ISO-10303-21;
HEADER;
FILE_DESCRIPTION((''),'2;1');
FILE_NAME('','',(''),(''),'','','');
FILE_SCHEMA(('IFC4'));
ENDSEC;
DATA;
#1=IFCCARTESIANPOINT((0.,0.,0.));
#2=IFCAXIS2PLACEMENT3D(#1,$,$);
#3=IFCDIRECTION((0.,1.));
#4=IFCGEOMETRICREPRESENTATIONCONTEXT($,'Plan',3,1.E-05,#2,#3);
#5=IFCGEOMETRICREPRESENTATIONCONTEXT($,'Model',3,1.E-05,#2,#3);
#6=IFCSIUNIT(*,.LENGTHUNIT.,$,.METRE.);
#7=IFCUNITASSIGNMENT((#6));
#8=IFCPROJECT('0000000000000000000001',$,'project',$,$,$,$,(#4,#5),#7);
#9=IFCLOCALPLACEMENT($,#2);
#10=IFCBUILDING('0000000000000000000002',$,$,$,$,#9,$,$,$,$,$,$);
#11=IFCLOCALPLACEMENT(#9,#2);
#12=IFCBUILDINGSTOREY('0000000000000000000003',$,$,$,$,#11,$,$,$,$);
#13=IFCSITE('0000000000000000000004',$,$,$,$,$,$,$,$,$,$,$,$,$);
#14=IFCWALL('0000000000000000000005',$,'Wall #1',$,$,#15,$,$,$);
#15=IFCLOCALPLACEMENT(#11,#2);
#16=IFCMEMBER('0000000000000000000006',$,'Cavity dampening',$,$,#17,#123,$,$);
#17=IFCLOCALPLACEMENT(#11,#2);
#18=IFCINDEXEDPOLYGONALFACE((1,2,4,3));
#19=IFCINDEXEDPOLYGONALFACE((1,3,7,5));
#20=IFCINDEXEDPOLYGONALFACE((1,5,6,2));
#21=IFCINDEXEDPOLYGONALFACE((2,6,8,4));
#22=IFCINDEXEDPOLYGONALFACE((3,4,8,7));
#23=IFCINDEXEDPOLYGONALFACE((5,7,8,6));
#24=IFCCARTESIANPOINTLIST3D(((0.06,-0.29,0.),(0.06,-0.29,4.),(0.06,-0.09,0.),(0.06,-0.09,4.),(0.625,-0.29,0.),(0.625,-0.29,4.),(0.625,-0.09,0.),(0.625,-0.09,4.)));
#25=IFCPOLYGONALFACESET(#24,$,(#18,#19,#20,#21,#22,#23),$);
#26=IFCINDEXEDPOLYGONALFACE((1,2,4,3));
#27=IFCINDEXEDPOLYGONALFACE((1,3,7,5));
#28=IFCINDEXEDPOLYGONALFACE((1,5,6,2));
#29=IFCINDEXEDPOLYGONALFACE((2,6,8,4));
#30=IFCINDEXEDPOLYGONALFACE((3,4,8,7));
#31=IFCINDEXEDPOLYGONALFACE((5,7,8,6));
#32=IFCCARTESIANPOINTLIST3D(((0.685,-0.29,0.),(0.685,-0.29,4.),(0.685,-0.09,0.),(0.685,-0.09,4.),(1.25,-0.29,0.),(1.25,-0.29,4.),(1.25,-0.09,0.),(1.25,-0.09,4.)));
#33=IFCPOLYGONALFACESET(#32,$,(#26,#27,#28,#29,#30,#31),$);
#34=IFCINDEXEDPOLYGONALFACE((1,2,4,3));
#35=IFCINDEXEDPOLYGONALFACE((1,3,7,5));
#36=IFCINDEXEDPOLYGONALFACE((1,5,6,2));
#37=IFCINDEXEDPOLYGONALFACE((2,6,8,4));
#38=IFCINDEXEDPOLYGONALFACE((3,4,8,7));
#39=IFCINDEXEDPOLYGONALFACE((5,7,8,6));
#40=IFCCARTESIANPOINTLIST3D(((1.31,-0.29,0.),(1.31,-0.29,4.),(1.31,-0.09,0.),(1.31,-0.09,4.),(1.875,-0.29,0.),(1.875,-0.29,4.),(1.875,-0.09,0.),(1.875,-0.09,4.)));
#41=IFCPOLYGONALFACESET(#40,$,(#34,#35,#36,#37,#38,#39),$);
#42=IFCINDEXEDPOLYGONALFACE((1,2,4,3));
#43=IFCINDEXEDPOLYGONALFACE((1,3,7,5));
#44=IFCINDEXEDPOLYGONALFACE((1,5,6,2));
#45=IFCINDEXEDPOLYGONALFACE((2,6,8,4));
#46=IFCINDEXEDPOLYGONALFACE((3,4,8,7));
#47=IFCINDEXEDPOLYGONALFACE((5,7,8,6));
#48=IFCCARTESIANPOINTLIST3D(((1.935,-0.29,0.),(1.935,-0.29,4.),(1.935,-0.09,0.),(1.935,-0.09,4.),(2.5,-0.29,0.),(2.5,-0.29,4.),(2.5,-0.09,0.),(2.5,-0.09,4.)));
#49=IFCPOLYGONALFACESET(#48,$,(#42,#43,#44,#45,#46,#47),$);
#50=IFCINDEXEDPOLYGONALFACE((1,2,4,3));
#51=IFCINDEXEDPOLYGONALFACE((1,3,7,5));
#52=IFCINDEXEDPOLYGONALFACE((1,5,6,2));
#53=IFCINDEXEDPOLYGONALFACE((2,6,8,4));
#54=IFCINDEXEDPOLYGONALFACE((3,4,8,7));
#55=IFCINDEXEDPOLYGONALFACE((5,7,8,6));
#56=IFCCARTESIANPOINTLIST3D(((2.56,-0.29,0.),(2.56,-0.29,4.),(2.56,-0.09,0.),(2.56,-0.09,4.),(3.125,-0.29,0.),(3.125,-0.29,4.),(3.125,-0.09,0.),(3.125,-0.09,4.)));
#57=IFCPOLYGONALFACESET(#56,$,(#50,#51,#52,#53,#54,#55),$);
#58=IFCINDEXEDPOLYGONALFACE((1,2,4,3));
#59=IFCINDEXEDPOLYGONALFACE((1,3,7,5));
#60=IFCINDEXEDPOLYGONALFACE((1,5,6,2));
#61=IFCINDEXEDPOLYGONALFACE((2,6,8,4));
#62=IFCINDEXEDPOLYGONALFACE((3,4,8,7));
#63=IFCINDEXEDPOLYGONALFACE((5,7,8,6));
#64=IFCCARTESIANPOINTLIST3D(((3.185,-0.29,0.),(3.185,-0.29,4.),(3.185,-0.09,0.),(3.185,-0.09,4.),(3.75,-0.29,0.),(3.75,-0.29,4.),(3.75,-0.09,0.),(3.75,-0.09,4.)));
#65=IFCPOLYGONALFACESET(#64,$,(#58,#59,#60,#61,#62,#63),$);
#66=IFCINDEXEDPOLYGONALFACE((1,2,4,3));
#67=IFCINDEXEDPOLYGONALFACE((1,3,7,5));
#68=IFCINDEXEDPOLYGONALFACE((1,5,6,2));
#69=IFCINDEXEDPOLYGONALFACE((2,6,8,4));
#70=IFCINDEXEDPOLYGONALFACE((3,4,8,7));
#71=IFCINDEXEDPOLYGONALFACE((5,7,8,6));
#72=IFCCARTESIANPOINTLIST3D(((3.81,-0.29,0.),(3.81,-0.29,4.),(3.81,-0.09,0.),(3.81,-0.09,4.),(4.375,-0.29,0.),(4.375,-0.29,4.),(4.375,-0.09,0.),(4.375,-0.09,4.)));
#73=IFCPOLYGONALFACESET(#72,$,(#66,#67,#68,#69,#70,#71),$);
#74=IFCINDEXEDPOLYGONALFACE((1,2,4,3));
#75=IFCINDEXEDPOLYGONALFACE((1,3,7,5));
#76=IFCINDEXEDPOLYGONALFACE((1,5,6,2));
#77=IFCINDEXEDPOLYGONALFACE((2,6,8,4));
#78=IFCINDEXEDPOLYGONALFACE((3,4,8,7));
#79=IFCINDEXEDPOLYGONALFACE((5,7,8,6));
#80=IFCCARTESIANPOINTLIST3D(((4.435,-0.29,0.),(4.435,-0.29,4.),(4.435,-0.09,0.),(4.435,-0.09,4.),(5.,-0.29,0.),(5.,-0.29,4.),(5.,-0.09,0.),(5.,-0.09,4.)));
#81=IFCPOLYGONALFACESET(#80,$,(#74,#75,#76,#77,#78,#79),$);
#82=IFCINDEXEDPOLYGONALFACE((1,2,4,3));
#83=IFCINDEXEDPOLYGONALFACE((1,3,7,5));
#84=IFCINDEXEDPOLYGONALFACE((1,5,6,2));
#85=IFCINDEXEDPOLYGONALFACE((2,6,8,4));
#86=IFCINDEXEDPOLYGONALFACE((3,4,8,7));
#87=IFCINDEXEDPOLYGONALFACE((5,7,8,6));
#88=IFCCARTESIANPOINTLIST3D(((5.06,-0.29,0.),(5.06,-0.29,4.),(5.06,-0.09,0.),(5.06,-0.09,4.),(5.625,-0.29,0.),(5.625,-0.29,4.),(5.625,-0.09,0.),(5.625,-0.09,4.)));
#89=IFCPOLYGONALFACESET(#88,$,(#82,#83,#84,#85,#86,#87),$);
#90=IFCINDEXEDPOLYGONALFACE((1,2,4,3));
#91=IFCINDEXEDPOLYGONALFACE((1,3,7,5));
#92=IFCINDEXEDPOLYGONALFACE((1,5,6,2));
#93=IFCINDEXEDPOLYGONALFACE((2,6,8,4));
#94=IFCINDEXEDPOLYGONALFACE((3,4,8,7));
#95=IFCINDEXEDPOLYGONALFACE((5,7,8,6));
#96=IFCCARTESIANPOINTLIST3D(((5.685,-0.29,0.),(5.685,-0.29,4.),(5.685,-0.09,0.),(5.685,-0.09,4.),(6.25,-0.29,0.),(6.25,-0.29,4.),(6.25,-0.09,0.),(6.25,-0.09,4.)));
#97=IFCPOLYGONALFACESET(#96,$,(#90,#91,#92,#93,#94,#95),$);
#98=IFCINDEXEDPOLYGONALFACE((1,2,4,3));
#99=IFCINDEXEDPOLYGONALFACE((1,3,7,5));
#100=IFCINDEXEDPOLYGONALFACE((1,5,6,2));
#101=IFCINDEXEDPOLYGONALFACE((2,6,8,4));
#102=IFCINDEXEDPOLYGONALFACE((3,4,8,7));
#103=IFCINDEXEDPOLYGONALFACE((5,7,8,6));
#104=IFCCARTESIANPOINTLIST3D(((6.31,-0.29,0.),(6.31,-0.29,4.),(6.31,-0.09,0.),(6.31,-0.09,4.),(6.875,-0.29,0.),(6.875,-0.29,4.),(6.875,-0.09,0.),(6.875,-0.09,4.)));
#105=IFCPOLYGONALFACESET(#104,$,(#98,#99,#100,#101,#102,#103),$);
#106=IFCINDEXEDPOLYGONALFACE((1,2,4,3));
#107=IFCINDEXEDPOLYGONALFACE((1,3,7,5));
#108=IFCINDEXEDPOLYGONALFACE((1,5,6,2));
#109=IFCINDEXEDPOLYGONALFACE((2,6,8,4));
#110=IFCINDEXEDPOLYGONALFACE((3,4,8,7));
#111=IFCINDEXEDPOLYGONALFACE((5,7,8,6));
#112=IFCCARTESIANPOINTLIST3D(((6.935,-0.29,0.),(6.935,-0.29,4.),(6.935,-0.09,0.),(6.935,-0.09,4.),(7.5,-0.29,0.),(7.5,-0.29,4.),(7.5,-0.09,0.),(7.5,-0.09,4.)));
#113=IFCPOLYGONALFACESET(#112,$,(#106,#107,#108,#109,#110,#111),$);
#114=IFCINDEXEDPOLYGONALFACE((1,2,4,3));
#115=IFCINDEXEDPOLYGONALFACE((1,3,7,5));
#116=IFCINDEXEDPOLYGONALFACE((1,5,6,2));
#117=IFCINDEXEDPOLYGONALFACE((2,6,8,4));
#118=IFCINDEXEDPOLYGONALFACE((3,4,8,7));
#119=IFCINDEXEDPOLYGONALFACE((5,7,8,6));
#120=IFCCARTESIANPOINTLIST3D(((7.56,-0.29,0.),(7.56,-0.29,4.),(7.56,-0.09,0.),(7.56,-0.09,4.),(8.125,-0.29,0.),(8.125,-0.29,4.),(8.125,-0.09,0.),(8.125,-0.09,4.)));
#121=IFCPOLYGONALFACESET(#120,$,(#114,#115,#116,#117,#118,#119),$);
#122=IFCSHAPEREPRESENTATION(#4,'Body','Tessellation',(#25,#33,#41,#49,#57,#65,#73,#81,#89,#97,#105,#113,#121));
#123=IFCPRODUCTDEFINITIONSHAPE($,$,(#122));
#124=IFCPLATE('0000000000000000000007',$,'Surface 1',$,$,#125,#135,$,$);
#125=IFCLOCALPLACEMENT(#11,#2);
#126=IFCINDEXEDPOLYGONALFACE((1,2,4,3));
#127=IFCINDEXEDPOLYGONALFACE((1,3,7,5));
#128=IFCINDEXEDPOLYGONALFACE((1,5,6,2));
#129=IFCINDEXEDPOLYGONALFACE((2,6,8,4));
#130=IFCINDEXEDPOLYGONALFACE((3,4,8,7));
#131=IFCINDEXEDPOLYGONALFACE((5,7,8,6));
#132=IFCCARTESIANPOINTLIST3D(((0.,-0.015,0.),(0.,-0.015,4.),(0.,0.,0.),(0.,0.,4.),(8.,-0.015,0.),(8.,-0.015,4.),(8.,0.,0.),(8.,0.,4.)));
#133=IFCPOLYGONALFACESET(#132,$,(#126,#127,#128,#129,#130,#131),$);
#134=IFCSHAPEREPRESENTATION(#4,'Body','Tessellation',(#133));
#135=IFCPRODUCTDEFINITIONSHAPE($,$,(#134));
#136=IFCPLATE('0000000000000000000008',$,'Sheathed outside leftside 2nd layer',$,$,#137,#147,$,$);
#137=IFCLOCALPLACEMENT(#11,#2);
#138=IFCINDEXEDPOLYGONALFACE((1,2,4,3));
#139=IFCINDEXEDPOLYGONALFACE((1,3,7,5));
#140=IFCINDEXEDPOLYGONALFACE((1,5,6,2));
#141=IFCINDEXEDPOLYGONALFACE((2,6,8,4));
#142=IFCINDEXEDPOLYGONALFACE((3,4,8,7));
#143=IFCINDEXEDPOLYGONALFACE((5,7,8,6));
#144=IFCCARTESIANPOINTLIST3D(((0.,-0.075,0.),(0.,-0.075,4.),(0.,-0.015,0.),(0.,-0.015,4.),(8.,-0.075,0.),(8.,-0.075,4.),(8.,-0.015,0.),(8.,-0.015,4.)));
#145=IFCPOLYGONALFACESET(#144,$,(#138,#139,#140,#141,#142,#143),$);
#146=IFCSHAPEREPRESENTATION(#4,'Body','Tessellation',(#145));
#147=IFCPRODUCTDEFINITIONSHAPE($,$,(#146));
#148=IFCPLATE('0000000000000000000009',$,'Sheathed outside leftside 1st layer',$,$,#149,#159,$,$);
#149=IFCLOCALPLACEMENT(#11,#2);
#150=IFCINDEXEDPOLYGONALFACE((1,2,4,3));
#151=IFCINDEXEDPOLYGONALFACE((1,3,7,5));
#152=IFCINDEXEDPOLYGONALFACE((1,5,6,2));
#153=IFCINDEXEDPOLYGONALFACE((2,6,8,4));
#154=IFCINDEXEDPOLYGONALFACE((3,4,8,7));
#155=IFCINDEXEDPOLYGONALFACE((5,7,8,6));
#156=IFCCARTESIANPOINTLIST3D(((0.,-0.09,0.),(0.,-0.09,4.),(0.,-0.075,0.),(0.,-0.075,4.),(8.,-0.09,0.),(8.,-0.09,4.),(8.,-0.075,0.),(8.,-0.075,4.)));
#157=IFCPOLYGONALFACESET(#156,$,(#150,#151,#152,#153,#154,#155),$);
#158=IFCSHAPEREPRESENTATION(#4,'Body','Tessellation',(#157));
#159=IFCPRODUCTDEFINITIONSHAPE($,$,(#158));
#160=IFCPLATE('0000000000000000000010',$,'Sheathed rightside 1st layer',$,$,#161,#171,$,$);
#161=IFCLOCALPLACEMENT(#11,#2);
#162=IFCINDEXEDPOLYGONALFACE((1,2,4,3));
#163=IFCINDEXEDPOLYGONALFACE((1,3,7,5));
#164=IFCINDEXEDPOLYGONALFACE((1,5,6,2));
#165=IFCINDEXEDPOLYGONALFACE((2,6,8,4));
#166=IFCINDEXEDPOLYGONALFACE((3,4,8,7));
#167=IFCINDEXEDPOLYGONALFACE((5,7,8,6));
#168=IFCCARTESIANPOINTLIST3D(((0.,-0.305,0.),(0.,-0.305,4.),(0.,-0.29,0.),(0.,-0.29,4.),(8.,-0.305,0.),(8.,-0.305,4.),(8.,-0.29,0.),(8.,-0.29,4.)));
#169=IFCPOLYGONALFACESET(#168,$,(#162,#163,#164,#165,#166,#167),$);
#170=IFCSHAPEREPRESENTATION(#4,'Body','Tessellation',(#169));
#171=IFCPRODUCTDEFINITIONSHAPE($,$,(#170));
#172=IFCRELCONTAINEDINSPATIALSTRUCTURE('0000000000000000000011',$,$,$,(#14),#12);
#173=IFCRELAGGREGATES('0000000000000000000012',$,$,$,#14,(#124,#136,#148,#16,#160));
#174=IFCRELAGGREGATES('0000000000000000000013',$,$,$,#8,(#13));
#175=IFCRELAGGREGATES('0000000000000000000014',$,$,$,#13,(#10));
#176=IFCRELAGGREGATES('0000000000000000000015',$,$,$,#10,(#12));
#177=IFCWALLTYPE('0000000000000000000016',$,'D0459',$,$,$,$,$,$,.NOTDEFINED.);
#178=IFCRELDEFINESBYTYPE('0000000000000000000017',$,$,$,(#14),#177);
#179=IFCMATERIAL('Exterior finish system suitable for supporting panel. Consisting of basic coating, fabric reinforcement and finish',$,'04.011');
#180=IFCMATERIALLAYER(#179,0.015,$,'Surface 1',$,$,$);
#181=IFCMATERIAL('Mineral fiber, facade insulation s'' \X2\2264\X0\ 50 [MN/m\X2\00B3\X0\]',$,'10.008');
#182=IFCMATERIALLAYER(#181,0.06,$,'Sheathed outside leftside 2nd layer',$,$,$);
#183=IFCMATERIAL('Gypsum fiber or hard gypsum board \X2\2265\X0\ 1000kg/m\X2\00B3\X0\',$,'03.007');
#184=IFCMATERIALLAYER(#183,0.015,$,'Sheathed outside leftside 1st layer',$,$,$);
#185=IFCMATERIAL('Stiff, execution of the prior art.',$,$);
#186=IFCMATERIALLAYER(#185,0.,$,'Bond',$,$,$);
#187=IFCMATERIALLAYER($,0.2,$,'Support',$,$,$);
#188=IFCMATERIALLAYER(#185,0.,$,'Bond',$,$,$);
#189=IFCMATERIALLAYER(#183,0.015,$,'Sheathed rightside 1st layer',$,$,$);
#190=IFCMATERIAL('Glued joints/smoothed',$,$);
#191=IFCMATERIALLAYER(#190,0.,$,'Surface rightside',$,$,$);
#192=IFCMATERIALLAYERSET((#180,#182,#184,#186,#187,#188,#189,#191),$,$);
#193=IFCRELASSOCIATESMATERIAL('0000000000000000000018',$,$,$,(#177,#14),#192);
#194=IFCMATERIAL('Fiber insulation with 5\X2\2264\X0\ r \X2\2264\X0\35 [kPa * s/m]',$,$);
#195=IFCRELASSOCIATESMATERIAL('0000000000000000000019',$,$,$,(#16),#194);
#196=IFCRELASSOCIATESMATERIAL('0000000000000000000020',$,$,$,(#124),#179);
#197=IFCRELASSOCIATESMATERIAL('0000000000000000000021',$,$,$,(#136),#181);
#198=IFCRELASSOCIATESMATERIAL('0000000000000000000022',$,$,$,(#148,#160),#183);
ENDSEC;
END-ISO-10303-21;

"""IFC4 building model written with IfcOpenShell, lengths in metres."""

from ifc_helpers import new_model, si_unit, direction, frame, frame_2d, origin, origin_with_axes, place, context, project, spatial, rectangle, extrude, material, layer, layer_set, type_object, element, aggregate, save


model = new_model("IFC4")

# Units and contexts
plan_context = context("Plan", 3, precision=1e-05, world=origin(), true_north=direction((0.0, 1.0)))
model_context = context("Model", 3, precision=1e-05, world=origin(), true_north=direction((0.0, 1.0)))
ifc_project = project(units=[si_unit("LENGTHUNIT", "METRE")], contexts=[plan_context, model_context])

# Site, building, storey
site = spatial("IfcSite", under=ifc_project)
building_placement = place(None, origin())
building = spatial("IfcBuilding", under=site, at=building_placement)
storey_placement = place(building_placement, origin())
storey = spatial("IfcBuildingStorey", under=building, at=storey_placement)

# Wall, member, plates
ifc_material_1 = material(Name="Exterior finish system suitable for supporting panel. Consisting of basic coating, fabric reinforcement and finish", Category="04.011")
ifc_layer_1 = layer(ifc_material_1, 0.015, Name="Surface 1")
ifc_material_2 = material(Name="Mineral fiber, facade insulation s' ≤ 50 [MN/m³]", Category="10.008")
ifc_layer_2 = layer(ifc_material_2, 0.06, Name="Sheathed outside leftside 2nd layer")
ifc_material_3 = material(Name="Gypsum fiber or hard gypsum board ≥ 1000kg/m³", Category="03.007")
ifc_layer_3 = layer(ifc_material_3, 0.015, Name="Sheathed outside leftside 1st layer")
ifc_material_4 = material(Name="Stiff, execution of the prior art.")
ifc_layer_4 = layer(ifc_material_4, 0.0, Name="Bond")
ifc_layer_5 = layer(None, 0.2, Name="Support")
ifc_layer_6 = layer(ifc_material_4, 0.0, Name="Bond")
ifc_layer_7 = layer(ifc_material_3, 0.015, Name="Sheathed rightside 1st layer")
ifc_material_5 = material(Name="Glued joints/smoothed")
ifc_layer_8 = layer(ifc_material_5, 0.0, Name="Surface rightside")
ifc_layer_set = layer_set([ifc_layer_1, ifc_layer_2, ifc_layer_3, ifc_layer_4, ifc_layer_5, ifc_layer_6, ifc_layer_7, ifc_layer_8])
wall_type = type_object("IfcWallType", Name="D0459", PredefinedType="NOTDEFINED", material=ifc_layer_set)
wall_placement = place(None, frame((0.0, 0.0, 0.0), z_axis=(0.0, -1.0, 0.0), x_axis=(1.0, 0.0, 0.0)))
wall = element("IfcWall", 1, at=wall_placement, inside=storey, type_object=wall_type, material=ifc_layer_set, Name="Wall #1")
ifc_material_6 = material(Name="Fiber insulation with 5≤ r ≤35 [kPa * s/m]")
member_1_placement = place(wall_placement, origin())
member_1 = element("IfcMember", 2, at=member_1_placement, material=ifc_material_6, Name="Cavity dampening", context=plan_context, shape_type="SweptSolid", body=[
    extrude(rectangle(XDim=0.565, YDim=0.2, at=frame_2d((0.2825, 0.1), x_axis=(1.0, 0.0))), frame((0.06, 4.0, 0.09), z_axis=(0.0, -1.0, 0.0), x_axis=(1.0, 0.0, 0.0)), (0.0, 0.0, 1.0), 4.0),
    extrude(rectangle(XDim=0.565, YDim=0.2, at=frame_2d((0.2825, 0.1), x_axis=(1.0, 0.0))), frame((0.685, 4.0, 0.09), z_axis=(0.0, -1.0, 0.0), x_axis=(1.0, 0.0, 0.0)), (0.0, 0.0, 1.0), 4.0),
    extrude(rectangle(XDim=0.565, YDim=0.2, at=frame_2d((0.2825, 0.1), x_axis=(1.0, 0.0))), frame((1.31, 4.0, 0.09), z_axis=(0.0, -1.0, 0.0), x_axis=(1.0, 0.0, 0.0)), (0.0, 0.0, 1.0), 4.0),
    extrude(rectangle(XDim=0.565, YDim=0.2, at=frame_2d((0.2825, 0.1), x_axis=(1.0, 0.0))), frame((1.935, 4.0, 0.09), z_axis=(0.0, -1.0, 0.0), x_axis=(1.0, 0.0, 0.0)), (0.0, 0.0, 1.0), 4.0),
    extrude(rectangle(XDim=0.565, YDim=0.2, at=frame_2d((0.2825, 0.1), x_axis=(1.0, 0.0))), frame((2.56, 4.0, 0.09), z_axis=(0.0, -1.0, 0.0), x_axis=(1.0, 0.0, 0.0)), (0.0, 0.0, 1.0), 4.0),
    extrude(rectangle(XDim=0.565, YDim=0.2, at=frame_2d((0.2825, 0.1), x_axis=(1.0, 0.0))), frame((3.185, 4.0, 0.09), z_axis=(0.0, -1.0, 0.0), x_axis=(1.0, 0.0, 0.0)), (0.0, 0.0, 1.0), 4.0),
    extrude(rectangle(XDim=0.565, YDim=0.2, at=frame_2d((0.2825, 0.1), x_axis=(1.0, 0.0))), frame((3.81, 4.0, 0.09), z_axis=(0.0, -1.0, 0.0), x_axis=(1.0, 0.0, 0.0)), (0.0, 0.0, 1.0), 4.0),
    extrude(rectangle(XDim=0.565, YDim=0.2, at=frame_2d((0.2825, 0.1), x_axis=(1.0, 0.0))), frame((4.435, 4.0, 0.09), z_axis=(0.0, -1.0, 0.0), x_axis=(1.0, 0.0, 0.0)), (0.0, 0.0, 1.0), 4.0),
    extrude(rectangle(XDim=0.565, YDim=0.2, at=frame_2d((0.2825, 0.1), x_axis=(1.0, 0.0))), frame((5.06, 4.0, 0.09), z_axis=(0.0, -1.0, 0.0), x_axis=(1.0, 0.0, 0.0)), (0.0, 0.0, 1.0), 4.0),
    extrude(rectangle(XDim=0.565, YDim=0.2, at=frame_2d((0.2825, 0.1), x_axis=(1.0, 0.0))), frame((5.685, 4.0, 0.09), z_axis=(0.0, -1.0, 0.0), x_axis=(1.0, 0.0, 0.0)), (0.0, 0.0, 1.0), 4.0),
    extrude(rectangle(XDim=0.565, YDim=0.2, at=frame_2d((0.2825, 0.1), x_axis=(1.0, 0.0))), frame((6.31, 4.0, 0.09), z_axis=(0.0, -1.0, 0.0), x_axis=(1.0, 0.0, 0.0)), (0.0, 0.0, 1.0), 4.0),
    extrude(rectangle(XDim=0.565, YDim=0.2, at=frame_2d((0.2825, 0.1), x_axis=(1.0, 0.0))), frame((6.935, 4.0, 0.09), z_axis=(0.0, -1.0, 0.0), x_axis=(1.0, 0.0, 0.0)), (0.0, 0.0, 1.0), 4.0),
    extrude(rectangle(XDim=0.565, YDim=0.2, at=frame_2d((0.2825, 0.1), x_axis=(1.0, 0.0))), frame((7.56, 4.0, 0.09), z_axis=(0.0, -1.0, 0.0), x_axis=(1.0, 0.0, 0.0)), (0.0, 0.0, 1.0), 4.0),
])
plate_1_placement = place(wall_placement, origin())
plate_1 = element("IfcPlate", 3, at=plate_1_placement, material=ifc_material_1, Name="Surface 1", context=plan_context, shape_type="SweptSolid", body=[
    extrude(rectangle(XDim=8.0, YDim=4.0, at=frame_2d((4.0, 2.0), x_axis=(1.0, 0.0))), origin_with_axes(), (0.0, 0.0, 1.0), 0.015),
])
plate_2_placement = place(wall_placement, origin())
plate_2 = element("IfcPlate", 4, at=plate_2_placement, material=ifc_material_2, Name="Sheathed outside leftside 2nd layer", context=plan_context, shape_type="SweptSolid", body=[
    extrude(rectangle(XDim=8.0, YDim=4.0, at=frame_2d((4.0, 2.0), x_axis=(1.0, 0.0))), frame((0.0, 0.0, 0.015), z_axis=(0.0, 0.0, 1.0), x_axis=(1.0, 0.0, 0.0)), (0.0, 0.0, 1.0), 0.06),
])
plate_3_placement = place(wall_placement, origin())
plate_3 = element("IfcPlate", 5, at=plate_3_placement, material=ifc_material_3, Name="Sheathed outside leftside 1st layer", context=plan_context, shape_type="SweptSolid", body=[
    extrude(rectangle(XDim=8.0, YDim=4.0, at=frame_2d((4.0, 2.0), x_axis=(1.0, 0.0))), frame((0.0, 0.0, 0.075), z_axis=(0.0, 0.0, 1.0), x_axis=(1.0, 0.0, 0.0)), (0.0, 0.0, 1.0), 0.015),
])
plate_4_placement = place(wall_placement, origin())
plate_4 = element("IfcPlate", 6, at=plate_4_placement, material=ifc_material_3, Name="Sheathed rightside 1st layer", context=plan_context, shape_type="SweptSolid", body=[
    extrude(rectangle(XDim=8.0, YDim=4.0, at=frame_2d((4.0, 2.0), x_axis=(1.0, 0.0))), frame((0.0, 0.0, 0.29), z_axis=(0.0, 0.0, 1.0), x_axis=(1.0, 0.0, 0.0)), (0.0, 0.0, 1.0), 0.015),
])
aggregate(wall, [plate_1, plate_2, plate_3, member_1, plate_4])

save(model, "model.ifc")
